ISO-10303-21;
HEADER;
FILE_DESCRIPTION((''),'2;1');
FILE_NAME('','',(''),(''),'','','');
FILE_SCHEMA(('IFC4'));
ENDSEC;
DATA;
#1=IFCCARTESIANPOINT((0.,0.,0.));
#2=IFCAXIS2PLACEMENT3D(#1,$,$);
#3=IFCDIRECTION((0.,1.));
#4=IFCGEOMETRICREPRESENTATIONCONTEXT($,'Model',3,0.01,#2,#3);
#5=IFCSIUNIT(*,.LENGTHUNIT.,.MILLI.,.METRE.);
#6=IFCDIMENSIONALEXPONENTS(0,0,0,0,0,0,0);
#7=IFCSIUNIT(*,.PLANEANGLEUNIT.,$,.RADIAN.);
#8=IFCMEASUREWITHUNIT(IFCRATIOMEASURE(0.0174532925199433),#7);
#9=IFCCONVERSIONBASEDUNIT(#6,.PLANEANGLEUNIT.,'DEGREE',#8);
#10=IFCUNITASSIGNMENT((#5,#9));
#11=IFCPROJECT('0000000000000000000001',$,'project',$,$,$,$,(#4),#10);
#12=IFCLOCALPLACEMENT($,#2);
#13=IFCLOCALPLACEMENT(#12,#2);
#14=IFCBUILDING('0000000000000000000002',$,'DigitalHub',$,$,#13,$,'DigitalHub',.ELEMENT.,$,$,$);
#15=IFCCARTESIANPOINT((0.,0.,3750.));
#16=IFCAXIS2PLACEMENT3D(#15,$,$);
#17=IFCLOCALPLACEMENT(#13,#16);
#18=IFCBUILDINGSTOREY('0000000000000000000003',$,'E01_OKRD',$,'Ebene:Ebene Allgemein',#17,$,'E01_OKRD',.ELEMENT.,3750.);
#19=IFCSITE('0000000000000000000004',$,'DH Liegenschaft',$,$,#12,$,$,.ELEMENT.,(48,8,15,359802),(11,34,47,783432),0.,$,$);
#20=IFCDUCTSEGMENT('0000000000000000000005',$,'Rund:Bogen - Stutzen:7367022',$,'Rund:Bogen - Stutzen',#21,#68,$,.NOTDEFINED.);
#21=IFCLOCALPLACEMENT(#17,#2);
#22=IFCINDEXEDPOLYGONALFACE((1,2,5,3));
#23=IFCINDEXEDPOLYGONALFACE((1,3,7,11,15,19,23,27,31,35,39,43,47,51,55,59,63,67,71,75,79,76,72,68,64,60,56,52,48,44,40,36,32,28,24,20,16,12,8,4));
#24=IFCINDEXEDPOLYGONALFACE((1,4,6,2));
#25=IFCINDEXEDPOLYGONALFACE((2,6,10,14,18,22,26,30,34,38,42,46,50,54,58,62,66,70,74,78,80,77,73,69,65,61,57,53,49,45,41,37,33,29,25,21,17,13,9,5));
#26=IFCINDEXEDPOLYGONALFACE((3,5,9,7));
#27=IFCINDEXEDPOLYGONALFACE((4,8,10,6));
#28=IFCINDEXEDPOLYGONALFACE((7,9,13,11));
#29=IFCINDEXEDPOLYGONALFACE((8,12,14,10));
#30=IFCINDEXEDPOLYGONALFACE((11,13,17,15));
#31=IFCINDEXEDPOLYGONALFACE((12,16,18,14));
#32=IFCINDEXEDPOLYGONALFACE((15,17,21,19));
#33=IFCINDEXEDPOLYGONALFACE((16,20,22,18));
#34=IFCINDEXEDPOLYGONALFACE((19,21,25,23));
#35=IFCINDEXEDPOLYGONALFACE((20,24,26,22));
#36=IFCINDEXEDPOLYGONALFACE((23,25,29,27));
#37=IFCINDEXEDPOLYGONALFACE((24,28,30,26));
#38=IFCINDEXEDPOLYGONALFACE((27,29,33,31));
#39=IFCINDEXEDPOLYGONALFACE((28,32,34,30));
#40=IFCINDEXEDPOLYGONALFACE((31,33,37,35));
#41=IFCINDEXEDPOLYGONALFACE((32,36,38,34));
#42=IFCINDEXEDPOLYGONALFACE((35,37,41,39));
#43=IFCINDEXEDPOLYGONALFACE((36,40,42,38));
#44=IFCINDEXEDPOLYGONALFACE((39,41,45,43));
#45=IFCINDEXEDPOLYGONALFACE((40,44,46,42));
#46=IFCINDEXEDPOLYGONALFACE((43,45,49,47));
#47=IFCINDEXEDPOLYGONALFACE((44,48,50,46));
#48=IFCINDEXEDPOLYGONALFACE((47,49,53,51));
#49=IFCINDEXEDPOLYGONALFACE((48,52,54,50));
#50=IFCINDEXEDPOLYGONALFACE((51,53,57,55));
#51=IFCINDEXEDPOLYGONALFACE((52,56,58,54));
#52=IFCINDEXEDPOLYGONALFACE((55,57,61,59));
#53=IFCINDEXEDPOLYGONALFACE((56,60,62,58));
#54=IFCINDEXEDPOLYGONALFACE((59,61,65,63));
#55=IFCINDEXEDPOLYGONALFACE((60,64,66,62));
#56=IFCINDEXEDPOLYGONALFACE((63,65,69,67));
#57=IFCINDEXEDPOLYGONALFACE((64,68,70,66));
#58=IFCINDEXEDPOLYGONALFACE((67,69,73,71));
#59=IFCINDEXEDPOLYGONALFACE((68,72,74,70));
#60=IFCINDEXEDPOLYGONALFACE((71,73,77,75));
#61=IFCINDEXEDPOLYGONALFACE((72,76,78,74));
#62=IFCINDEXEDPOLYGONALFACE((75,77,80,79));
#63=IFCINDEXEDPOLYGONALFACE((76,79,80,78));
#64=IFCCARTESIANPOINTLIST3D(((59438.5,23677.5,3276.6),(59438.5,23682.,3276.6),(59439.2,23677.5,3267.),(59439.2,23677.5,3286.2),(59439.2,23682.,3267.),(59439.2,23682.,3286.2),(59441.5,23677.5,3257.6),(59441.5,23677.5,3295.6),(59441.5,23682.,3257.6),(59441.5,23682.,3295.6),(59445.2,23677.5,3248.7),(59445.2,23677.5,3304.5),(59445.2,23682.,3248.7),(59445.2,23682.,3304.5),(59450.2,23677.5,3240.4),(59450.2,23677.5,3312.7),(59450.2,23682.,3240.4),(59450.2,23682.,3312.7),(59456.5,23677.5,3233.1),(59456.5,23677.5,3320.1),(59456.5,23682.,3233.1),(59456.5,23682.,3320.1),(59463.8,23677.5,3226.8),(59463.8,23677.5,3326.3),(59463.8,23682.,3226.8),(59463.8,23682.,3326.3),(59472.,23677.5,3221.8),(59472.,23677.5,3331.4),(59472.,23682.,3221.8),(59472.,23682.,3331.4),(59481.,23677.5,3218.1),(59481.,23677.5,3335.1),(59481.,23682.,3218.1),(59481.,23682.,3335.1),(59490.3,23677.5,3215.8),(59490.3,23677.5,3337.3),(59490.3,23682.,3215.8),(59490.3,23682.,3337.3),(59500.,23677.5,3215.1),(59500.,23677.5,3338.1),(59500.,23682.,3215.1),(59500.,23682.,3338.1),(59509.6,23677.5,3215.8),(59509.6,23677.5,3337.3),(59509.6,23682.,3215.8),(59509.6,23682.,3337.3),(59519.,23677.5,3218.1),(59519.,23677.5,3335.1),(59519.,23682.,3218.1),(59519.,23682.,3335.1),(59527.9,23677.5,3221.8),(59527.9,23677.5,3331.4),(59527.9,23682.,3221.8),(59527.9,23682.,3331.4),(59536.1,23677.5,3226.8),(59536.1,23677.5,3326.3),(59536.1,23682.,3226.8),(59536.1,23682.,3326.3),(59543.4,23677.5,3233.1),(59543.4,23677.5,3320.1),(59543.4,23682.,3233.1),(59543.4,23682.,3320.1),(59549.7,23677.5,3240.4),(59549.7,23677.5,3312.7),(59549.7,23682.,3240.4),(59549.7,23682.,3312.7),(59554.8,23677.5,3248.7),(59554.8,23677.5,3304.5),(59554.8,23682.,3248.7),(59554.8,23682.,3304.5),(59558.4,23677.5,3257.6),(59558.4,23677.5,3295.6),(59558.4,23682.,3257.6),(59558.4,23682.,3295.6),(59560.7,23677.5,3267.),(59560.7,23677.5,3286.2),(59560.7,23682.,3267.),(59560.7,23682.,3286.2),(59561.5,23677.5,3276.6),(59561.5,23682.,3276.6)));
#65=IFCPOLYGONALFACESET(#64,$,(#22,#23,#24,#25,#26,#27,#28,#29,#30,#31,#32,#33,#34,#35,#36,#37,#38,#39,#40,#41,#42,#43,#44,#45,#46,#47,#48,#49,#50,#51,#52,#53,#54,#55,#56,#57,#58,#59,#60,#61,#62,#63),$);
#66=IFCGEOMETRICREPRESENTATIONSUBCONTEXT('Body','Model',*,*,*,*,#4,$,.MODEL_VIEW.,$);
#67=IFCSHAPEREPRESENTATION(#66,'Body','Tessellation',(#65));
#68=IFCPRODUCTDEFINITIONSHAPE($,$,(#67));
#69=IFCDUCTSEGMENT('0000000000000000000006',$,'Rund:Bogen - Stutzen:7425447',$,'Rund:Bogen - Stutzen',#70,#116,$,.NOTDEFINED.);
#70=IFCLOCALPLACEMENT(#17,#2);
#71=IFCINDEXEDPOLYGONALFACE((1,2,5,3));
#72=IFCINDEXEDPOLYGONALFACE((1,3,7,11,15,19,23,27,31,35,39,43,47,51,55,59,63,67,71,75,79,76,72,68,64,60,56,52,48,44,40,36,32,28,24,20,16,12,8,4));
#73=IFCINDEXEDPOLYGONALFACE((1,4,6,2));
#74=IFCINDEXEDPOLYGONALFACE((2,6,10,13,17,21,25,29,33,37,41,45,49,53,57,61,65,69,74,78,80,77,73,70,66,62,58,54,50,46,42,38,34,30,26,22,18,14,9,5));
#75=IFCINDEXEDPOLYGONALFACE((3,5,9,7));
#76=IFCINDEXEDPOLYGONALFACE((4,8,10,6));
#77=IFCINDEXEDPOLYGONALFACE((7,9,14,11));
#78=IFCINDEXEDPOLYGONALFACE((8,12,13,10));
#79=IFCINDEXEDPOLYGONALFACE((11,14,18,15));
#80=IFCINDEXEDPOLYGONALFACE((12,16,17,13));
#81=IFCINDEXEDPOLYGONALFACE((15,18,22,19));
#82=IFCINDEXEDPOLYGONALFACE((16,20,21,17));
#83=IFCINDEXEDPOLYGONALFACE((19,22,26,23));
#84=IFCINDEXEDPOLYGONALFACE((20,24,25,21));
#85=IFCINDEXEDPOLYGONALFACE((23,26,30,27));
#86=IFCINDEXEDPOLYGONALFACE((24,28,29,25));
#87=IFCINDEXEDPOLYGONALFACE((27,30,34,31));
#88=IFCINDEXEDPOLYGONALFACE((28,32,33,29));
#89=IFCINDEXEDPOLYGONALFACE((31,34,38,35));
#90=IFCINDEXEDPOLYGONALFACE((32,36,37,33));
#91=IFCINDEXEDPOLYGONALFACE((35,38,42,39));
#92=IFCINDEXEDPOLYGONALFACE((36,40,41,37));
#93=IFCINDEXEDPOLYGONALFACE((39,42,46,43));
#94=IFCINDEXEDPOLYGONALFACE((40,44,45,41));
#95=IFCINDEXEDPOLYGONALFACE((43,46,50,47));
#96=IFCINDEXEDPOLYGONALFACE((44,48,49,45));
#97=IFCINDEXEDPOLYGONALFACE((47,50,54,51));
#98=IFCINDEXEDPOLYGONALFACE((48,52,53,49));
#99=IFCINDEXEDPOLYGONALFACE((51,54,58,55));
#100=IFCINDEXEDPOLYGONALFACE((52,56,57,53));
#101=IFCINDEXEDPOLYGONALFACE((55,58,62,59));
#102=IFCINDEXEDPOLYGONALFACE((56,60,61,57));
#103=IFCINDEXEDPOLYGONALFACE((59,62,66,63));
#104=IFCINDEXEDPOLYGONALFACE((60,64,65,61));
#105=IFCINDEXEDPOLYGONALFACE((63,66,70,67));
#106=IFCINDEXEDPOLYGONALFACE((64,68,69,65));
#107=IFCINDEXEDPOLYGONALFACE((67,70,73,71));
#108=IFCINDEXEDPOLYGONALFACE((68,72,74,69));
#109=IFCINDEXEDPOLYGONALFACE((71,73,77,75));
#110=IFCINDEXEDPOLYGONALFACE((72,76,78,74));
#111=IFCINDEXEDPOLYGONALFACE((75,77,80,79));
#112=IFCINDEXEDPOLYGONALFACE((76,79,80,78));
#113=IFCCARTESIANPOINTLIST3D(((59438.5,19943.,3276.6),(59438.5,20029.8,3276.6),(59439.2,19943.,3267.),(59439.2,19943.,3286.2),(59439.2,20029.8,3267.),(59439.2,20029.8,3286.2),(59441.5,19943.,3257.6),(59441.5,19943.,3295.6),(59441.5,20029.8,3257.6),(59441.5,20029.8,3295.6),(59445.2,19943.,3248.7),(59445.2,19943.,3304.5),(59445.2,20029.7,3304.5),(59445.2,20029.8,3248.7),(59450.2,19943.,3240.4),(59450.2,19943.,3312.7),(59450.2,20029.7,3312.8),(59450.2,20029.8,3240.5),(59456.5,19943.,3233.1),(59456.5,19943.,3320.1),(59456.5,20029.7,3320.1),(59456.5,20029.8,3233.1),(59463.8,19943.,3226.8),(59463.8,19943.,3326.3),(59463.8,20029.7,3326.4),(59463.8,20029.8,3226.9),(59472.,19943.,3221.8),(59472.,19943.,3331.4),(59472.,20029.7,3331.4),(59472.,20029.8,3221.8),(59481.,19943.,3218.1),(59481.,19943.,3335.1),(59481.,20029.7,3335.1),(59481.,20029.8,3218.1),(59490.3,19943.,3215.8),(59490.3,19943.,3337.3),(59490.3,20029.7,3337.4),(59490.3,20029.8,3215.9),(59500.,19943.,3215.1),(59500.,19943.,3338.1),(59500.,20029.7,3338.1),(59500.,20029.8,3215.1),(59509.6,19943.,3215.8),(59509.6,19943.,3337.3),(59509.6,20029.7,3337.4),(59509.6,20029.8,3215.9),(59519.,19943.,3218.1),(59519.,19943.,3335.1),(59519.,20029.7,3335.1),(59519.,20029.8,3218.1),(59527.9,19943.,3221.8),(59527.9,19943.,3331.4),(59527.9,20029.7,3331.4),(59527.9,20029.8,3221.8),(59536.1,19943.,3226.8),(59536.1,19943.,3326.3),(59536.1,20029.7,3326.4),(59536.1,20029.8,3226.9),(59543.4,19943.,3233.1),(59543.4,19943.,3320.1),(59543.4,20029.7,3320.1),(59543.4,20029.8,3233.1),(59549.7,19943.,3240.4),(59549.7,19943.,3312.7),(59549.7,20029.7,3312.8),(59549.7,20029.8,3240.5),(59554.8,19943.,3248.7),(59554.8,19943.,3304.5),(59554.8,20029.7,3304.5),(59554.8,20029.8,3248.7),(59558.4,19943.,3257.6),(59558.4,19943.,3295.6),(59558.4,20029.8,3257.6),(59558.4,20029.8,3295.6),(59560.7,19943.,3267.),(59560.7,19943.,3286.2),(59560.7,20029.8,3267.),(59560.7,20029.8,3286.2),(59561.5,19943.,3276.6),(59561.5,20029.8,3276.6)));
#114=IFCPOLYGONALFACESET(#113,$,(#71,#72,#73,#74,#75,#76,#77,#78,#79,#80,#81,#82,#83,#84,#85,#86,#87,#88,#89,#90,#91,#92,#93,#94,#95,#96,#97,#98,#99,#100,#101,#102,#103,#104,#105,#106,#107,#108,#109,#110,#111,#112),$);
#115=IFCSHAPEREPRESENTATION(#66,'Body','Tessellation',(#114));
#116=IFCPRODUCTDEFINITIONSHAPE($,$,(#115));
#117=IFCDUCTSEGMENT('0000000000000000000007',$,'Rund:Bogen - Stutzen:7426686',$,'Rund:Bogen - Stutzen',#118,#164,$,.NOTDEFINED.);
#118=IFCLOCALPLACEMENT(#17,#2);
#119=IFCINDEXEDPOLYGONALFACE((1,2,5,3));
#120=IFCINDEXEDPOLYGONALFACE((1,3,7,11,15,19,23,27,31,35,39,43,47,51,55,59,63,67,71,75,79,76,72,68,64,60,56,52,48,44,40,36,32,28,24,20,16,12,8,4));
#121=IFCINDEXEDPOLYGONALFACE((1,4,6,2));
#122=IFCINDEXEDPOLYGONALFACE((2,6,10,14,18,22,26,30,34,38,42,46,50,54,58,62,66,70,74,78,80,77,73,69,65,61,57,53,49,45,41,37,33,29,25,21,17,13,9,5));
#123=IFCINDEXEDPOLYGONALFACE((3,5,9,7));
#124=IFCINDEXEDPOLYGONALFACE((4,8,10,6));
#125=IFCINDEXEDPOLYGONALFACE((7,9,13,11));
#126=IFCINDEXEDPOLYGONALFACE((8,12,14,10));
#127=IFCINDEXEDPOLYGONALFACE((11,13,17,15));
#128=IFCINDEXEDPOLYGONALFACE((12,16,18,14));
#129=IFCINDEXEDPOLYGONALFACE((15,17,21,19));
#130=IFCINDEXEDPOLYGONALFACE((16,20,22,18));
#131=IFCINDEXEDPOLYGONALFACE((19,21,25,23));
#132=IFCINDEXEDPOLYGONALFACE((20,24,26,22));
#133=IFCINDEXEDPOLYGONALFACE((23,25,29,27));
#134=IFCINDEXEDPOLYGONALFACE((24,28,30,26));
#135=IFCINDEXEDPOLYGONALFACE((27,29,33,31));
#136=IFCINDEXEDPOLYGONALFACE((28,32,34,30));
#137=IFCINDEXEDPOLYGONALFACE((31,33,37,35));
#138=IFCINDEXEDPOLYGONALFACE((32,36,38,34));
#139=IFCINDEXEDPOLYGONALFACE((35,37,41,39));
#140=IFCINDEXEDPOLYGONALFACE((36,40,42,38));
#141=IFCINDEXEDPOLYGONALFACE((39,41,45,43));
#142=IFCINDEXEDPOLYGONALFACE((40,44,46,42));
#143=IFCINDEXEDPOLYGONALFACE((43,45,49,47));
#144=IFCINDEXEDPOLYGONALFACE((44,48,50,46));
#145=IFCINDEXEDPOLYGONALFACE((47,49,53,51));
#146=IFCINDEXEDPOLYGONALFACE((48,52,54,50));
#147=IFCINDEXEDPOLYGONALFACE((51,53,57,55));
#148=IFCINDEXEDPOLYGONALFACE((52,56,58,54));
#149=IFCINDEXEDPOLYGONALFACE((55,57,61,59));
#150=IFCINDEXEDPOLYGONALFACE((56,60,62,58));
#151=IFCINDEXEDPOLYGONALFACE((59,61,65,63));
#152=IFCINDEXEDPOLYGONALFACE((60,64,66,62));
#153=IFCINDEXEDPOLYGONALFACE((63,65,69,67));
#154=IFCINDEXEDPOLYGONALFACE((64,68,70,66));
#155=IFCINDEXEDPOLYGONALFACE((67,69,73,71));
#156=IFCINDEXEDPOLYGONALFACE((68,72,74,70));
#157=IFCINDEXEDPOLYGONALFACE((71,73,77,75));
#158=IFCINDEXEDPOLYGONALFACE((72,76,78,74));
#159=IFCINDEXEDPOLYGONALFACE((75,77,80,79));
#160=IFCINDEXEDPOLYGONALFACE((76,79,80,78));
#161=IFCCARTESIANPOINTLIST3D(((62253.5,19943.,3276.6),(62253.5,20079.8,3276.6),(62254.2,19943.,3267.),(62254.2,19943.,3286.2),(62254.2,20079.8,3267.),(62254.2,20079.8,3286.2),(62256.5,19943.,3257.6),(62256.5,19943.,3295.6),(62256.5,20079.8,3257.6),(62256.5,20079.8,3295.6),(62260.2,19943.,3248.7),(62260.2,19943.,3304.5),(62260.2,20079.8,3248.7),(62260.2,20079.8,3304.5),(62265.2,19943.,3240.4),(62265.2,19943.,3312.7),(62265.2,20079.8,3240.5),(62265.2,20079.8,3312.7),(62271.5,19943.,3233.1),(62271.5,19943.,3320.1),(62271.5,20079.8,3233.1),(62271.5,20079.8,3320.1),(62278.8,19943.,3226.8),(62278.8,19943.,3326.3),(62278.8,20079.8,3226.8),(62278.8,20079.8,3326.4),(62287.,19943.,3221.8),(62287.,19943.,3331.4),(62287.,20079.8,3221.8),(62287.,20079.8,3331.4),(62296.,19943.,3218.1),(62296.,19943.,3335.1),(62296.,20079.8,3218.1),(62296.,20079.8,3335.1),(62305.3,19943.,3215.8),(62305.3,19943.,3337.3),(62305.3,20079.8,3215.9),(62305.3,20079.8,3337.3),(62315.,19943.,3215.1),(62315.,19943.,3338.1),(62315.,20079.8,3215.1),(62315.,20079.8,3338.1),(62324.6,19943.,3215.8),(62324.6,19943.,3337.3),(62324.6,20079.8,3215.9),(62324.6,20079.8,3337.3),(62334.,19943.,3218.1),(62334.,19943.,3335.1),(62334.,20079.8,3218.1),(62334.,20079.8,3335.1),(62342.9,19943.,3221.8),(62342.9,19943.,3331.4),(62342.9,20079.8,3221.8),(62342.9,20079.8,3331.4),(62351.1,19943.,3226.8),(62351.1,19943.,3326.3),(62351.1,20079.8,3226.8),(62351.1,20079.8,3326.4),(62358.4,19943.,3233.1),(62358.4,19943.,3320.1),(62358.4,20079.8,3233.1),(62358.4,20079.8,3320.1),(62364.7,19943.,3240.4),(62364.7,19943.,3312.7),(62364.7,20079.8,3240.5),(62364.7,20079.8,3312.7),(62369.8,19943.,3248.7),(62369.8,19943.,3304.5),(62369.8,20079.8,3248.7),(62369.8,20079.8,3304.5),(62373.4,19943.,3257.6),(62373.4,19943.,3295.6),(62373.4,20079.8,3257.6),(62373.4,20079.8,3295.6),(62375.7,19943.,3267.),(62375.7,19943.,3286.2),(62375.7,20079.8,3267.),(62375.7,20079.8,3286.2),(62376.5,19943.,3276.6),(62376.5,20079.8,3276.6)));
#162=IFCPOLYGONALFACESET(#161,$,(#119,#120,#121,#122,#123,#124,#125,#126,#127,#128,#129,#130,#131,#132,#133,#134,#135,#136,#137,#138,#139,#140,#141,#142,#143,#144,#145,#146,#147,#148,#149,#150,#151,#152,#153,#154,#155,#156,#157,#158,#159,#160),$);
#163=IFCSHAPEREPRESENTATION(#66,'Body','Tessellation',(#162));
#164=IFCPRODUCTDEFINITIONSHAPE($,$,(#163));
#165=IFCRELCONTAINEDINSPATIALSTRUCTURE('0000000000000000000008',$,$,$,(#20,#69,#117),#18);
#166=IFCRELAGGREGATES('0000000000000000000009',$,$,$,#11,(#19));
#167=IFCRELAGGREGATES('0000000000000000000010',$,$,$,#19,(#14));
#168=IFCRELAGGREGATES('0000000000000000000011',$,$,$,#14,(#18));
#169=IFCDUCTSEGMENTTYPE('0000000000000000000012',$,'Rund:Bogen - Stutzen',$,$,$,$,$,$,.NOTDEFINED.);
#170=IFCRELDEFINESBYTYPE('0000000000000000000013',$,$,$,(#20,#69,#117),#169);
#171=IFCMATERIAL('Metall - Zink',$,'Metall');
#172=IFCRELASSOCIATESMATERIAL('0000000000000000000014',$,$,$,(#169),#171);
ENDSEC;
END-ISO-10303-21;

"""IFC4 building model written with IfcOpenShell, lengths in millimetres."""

from ifc_helpers import new_model, entity, si_unit, converted_unit, direction, frame, origin, place, context, subcontext, project, spatial, indexed_curve, outline, extrude, material, type_object, element, save


model = new_model("IFC4")

# Units and contexts
model_context = context("Model", 3, precision=0.01, world=origin(), true_north=direction((0.0, 1.0)))
body_context = subcontext(model_context, "Body", "Model", "MODEL_VIEW")
ifc_project = project(units=[si_unit("LENGTHUNIT", "METRE", prefix="MILLI"), converted_unit("PLANEANGLEUNIT", "DEGREE", entity("IfcRatioMeasure", 0.0174532925199433), si_unit("PLANEANGLEUNIT", "RADIAN"), dimensions=[0, 0, 0, 0, 0, 0, 0])], contexts=[model_context])

# Site, building, storey
site_placement = place(None, origin())
site = spatial("IfcSite", under=ifc_project, at=site_placement, Name="DH Liegenschaft", CompositionType="ELEMENT", RefLatitude=(48, 8, 15, 359802), RefLongitude=(11, 34, 47, 783432), RefElevation=0.0)
building_placement = place(site_placement, origin())
building = spatial("IfcBuilding", under=site, at=building_placement, Name="DigitalHub", LongName="DigitalHub", CompositionType="ELEMENT")
storey_placement = place(building_placement, frame((0.0, 0.0, 3750.0)))
storey = spatial("IfcBuildingStorey", under=building, at=storey_placement, Name="E01_OKRD", ObjectType="Ebene:Ebene Allgemein", LongName="E01_OKRD", CompositionType="ELEMENT", Elevation=3750.0)

# Shared definitions
ifc_material_1 = material(Name="Metall - Zink", Category="Metall")

# Duct segments
duct_segment_type_1 = type_object("IfcDuctSegmentType", Name="Rund:Bogen - Stutzen", PredefinedType="NOTDEFINED", material=ifc_material_1)
duct_segment_1_placement = place(storey_placement, frame((59436.9, 23677.5, 3213.5)))
element("IfcDuctSegment", 1, at=duct_segment_1_placement, inside=storey, type_object=duct_segment_type_1, Name="Rund:Bogen - Stutzen:7367022", ObjectType="Rund:Bogen - Stutzen", PredefinedType="NOTDEFINED", context=body_context, shape_type="SweptSolid", body=[
    extrude(outline(indexed_curve([(61.5, 0.0), (60.7, 9.6), (58.5, 19.0), (54.8, 27.9), (49.8, 36.1), (43.5, 43.5), (36.1, 49.8), (27.9, 54.8), (19.0, 58.5), (9.6, 60.7), (0.0, 61.5), (-9.6, 60.7), (-19.0, 58.5), (-27.9, 54.8), (-36.1, 49.8), (-43.5, 43.5), (-49.8, 36.1), (-54.8, 27.9), (-58.5, 19.0), (-60.7, 9.6), (-61.5, 0.0), (-60.7, -9.6), (-58.5, -19.0), (-54.8, -27.9), (-49.8, -36.1), (-43.5, -43.5), (-36.1, -49.8), (-27.9, -54.8), (-19.0, -58.5), (-9.6, -60.7), (0.0, -61.5), (9.6, -60.7), (19.0, -58.5), (27.9, -54.8), (36.1, -49.8), (43.5, -43.5), (49.8, -36.1), (54.8, -27.9), (58.5, -19.0), (60.7, -9.6), (61.5, 0.0)], self_intersect=False)), frame((63.1, 0.0, 63.1), z_axis=(0.0, 1.0, 0.0), x_axis=(1.0, 0.0, 0.0)), (0.0, 0.0, 1.0), 4.5),
])
duct_segment_2_placement = place(storey_placement, frame((59436.9, 19943.0, 3213.5)))
element("IfcDuctSegment", 2, at=duct_segment_2_placement, inside=storey, type_object=duct_segment_type_1, Name="Rund:Bogen - Stutzen:7425447", ObjectType="Rund:Bogen - Stutzen", PredefinedType="NOTDEFINED", context=body_context, shape_type="SweptSolid", body=[
    extrude(outline(indexed_curve([(61.5, 0.0), (60.7, 9.6), (58.5, 19.0), (54.8, 27.9), (49.8, 36.1), (43.5, 43.5), (36.1, 49.8), (27.9, 54.8), (19.0, 58.5), (9.6, 60.7), (0.0, 61.5), (-9.6, 60.7), (-19.0, 58.5), (-27.9, 54.8), (-36.1, 49.8), (-43.5, 43.5), (-49.8, 36.1), (-54.8, 27.9), (-58.5, 19.0), (-60.7, 9.6), (-61.5, 0.0), (-60.7, -9.6), (-58.5, -19.0), (-54.8, -27.9), (-49.8, -36.1), (-43.5, -43.5), (-36.1, -49.8), (-27.9, -54.8), (-19.0, -58.5), (-9.6, -60.7), (0.0, -61.5), (9.6, -60.7), (19.0, -58.5), (27.9, -54.8), (36.1, -49.8), (43.5, -43.5), (49.8, -36.1), (54.8, -27.9), (58.5, -19.0), (60.7, -9.6), (61.5, 0.0)], self_intersect=False)), frame((63.1, 0.0, 63.1), z_axis=(0.0, 1.0, 0.000429), x_axis=(1.0, 0.0, 0.0)), (0.0, 0.0, 1.0), 86.8),
])
duct_segment_3_placement = place(storey_placement, frame((62251.9, 19943.0, 3213.5)))
element("IfcDuctSegment", 3, at=duct_segment_3_placement, inside=storey, type_object=duct_segment_type_1, Name="Rund:Bogen - Stutzen:7426686", ObjectType="Rund:Bogen - Stutzen", PredefinedType="NOTDEFINED", context=body_context, shape_type="SweptSolid", body=[
    extrude(outline(indexed_curve([(61.5, 0.0), (60.7, 9.6), (58.5, 19.0), (54.8, 27.9), (49.8, 36.1), (43.5, 43.5), (36.1, 49.8), (27.9, 54.8), (19.0, 58.5), (9.6, 60.7), (0.0, 61.5), (-9.6, 60.7), (-19.0, 58.5), (-27.9, 54.8), (-36.1, 49.8), (-43.5, 43.5), (-49.8, 36.1), (-54.8, 27.9), (-58.5, 19.0), (-60.7, 9.6), (-61.5, 0.0), (-60.7, -9.6), (-58.5, -19.0), (-54.8, -27.9), (-49.8, -36.1), (-43.5, -43.5), (-36.1, -49.8), (-27.9, -54.8), (-19.0, -58.5), (-9.6, -60.7), (0.0, -61.5), (9.6, -60.7), (19.0, -58.5), (27.9, -54.8), (36.1, -49.8), (43.5, -43.5), (49.8, -36.1), (54.8, -27.9), (58.5, -19.0), (60.7, -9.6), (61.5, 0.0)], self_intersect=False)), frame((63.1, 0.0, 63.1), z_axis=(0.0, 1.0, 0.000188), x_axis=(1.0, 0.0, 0.0)), (0.0, 0.0, 1.0), 136.8),
])

save(model, "model.ifc")
